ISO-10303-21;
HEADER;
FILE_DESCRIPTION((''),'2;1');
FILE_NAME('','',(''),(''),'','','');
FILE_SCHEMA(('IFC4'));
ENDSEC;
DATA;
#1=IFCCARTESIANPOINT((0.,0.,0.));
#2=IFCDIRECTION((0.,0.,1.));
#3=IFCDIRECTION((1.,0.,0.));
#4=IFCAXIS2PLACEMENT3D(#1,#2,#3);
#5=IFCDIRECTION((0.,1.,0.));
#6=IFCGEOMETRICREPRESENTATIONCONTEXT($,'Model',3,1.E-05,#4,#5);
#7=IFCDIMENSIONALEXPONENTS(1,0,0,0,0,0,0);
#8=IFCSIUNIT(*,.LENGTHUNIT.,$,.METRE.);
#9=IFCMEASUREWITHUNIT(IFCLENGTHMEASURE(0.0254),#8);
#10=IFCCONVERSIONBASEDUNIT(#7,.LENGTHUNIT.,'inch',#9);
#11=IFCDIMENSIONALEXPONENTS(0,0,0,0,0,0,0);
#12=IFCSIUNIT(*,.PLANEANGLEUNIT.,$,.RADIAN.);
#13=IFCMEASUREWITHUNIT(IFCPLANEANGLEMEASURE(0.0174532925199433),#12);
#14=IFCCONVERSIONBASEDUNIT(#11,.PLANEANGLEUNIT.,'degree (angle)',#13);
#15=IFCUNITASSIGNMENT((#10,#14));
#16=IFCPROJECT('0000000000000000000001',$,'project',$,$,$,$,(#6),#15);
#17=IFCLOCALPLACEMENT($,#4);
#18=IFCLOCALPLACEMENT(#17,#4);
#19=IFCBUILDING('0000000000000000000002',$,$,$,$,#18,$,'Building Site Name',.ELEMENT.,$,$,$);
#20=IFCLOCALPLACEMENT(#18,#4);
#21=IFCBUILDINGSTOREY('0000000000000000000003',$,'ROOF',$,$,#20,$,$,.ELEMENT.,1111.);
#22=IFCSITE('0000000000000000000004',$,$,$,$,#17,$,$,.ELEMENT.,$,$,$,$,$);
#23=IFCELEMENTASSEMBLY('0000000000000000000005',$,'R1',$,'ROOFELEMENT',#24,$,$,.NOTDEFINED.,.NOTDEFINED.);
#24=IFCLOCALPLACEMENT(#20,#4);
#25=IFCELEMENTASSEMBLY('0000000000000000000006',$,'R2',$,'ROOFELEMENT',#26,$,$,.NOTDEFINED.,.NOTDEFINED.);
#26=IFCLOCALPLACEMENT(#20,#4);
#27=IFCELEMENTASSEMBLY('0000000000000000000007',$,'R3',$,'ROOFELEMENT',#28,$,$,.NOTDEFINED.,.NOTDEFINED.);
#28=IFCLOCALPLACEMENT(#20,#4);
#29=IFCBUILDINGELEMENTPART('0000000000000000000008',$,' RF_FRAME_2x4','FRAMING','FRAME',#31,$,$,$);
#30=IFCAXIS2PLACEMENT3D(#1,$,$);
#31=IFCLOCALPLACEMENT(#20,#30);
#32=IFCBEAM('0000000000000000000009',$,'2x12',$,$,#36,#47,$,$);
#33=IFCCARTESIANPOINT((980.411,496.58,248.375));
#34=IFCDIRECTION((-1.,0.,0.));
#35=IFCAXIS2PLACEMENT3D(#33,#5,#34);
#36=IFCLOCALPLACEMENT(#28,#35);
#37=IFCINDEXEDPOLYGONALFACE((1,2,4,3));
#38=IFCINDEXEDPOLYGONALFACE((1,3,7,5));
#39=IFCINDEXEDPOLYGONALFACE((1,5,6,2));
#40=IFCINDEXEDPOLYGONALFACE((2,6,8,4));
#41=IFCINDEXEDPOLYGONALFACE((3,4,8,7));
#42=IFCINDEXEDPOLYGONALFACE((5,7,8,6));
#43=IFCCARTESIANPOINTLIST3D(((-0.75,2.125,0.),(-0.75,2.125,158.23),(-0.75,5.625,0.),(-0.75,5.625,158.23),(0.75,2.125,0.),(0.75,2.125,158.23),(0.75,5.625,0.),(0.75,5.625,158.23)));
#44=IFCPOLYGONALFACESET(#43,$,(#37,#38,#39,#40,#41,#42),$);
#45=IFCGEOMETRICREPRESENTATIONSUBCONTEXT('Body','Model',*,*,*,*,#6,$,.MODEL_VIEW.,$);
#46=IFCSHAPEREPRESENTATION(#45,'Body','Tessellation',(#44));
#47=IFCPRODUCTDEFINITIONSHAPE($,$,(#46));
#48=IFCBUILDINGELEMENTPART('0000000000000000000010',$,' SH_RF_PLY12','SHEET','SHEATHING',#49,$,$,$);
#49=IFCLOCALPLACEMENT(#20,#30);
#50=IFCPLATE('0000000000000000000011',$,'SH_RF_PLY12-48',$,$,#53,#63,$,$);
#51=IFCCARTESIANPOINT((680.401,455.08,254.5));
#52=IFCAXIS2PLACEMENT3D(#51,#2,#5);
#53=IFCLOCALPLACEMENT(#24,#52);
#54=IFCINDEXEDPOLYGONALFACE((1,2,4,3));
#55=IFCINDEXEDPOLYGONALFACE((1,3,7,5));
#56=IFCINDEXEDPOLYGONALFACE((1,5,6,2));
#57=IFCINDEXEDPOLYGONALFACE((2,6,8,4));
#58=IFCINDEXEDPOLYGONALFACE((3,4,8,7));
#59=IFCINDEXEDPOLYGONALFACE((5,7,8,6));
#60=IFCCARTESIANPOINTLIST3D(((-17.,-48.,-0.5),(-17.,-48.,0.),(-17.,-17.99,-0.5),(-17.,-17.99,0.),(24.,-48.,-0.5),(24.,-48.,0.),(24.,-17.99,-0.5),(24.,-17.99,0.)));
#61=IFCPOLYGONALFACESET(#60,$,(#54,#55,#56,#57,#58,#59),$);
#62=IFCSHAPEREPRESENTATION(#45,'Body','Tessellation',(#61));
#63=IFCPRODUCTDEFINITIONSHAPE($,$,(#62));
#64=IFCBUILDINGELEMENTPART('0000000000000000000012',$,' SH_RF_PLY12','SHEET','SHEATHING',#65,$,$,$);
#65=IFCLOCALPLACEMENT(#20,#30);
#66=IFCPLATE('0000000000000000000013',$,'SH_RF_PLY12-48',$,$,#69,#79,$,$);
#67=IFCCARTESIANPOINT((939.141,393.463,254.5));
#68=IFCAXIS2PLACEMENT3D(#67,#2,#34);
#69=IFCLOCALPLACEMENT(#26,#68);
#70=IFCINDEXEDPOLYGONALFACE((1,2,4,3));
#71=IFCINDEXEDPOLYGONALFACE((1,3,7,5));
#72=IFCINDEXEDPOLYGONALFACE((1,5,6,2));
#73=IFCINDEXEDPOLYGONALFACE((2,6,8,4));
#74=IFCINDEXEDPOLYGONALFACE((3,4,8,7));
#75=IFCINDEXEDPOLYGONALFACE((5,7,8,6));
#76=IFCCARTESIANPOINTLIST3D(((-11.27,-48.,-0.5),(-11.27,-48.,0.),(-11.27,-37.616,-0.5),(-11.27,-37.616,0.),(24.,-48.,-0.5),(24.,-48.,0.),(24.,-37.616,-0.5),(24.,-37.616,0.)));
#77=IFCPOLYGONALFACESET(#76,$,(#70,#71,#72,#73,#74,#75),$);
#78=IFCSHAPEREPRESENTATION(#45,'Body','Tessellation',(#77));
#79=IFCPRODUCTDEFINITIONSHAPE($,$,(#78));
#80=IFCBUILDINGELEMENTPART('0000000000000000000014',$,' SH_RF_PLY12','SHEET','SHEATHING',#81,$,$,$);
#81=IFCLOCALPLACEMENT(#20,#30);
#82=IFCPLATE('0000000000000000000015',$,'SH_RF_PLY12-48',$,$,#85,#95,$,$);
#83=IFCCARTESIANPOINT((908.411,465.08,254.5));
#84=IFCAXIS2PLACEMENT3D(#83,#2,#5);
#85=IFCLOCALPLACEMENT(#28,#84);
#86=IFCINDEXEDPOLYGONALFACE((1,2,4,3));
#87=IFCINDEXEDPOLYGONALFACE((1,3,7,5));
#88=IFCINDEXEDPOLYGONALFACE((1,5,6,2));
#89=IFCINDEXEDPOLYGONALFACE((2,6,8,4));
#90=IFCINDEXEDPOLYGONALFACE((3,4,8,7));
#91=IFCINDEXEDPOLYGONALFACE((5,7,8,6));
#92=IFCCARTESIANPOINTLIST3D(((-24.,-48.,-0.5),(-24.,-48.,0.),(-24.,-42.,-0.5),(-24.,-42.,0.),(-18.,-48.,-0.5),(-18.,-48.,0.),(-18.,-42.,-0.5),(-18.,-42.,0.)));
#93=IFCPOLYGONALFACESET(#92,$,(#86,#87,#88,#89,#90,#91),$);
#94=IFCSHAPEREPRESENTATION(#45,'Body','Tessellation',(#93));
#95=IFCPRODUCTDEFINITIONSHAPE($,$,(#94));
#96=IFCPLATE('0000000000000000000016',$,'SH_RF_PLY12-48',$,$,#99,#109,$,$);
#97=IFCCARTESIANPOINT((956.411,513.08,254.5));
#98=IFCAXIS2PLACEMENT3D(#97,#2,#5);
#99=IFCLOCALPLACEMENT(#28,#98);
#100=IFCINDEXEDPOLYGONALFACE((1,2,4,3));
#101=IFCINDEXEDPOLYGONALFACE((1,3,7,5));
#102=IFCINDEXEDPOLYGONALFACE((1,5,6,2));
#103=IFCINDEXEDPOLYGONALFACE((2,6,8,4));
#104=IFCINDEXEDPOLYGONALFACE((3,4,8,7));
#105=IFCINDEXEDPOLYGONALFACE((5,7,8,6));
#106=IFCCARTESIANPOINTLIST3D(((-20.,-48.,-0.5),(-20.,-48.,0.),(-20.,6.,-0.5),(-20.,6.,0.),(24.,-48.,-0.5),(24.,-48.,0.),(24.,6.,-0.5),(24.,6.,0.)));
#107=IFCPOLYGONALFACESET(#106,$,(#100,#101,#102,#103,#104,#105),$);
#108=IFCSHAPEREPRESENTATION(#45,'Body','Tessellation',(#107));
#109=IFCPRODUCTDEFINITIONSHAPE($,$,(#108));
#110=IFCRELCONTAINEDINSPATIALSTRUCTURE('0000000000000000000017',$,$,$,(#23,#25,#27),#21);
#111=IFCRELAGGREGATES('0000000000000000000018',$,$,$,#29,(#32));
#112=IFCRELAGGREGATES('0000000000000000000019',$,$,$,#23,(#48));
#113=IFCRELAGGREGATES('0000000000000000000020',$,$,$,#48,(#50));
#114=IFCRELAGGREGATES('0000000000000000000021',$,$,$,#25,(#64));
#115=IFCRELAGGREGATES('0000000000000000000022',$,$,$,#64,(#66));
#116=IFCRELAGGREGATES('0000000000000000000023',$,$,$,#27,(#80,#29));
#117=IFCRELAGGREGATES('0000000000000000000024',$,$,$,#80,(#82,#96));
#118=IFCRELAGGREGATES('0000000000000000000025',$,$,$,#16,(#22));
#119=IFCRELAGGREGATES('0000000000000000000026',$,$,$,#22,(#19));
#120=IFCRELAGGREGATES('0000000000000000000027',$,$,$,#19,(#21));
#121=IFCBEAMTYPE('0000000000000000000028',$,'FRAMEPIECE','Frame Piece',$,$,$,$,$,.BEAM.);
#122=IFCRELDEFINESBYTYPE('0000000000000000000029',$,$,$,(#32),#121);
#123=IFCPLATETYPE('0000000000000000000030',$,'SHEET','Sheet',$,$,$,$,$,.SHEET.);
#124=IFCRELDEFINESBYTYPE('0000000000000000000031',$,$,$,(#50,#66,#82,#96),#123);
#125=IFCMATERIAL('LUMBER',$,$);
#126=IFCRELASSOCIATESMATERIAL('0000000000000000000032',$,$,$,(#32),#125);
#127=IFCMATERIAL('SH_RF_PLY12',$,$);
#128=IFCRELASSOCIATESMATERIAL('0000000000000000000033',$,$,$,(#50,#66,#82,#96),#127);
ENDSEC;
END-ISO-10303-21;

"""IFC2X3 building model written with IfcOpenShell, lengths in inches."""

from ifc_helpers import new_model, entity, si_unit, converted_unit, direction, frame, frame_2d, origin_with_axes, place, context, subcontext, project, spatial, rectangle, extrude, material, type_object, element, aggregate, save


model = new_model("IFC2X3")

# Units and contexts
model_context = context("Model", 3, precision=1e-05, world=origin_with_axes(), true_north=direction((0.0, 1.0, 0.0)))
body_context = subcontext(model_context, "Body", "Model", "MODEL_VIEW")
ifc_project = project(units=[converted_unit("LENGTHUNIT", "inch", entity("IfcLengthMeasure", 0.0254), si_unit("LENGTHUNIT", "METRE"), dimensions=[1, 0, 0, 0, 0, 0, 0]), converted_unit("PLANEANGLEUNIT", "degree (angle)", entity("IfcPlaneAngleMeasure", 0.0174532925199433), si_unit("PLANEANGLEUNIT", "RADIAN"), dimensions=[0, 0, 0, 0, 0, 0, 0])], contexts=[model_context])

# Site, building, storey
site_placement = place(None, origin_with_axes())
site = spatial("IfcSite", under=ifc_project, at=site_placement, CompositionType="ELEMENT")
building_placement = place(site_placement, origin_with_axes())
building = spatial("IfcBuilding", under=site, at=building_placement, LongName="Building Site Name", CompositionType="ELEMENT")
storey_placement = place(building_placement, origin_with_axes())
storey = spatial("IfcBuildingStorey", under=building, at=storey_placement, Name="ROOF", CompositionType="ELEMENT", Elevation=1111.0)

# Element assemblies, building element part, beam
assembly_1_placement = place(storey_placement, origin_with_axes())
assembly_1 = element("IfcElementAssembly", 1, at=assembly_1_placement, inside=storey, Name="R1", ObjectType="ROOFELEMENT", AssemblyPlace="NOTDEFINED", PredefinedType="NOTDEFINED")
ifc_material_1 = material(Name="LUMBER")
beam_type = type_object("IfcBeamType", Name="FRAMEPIECE", Description="Frame Piece", PredefinedType="BEAM")
assembly_2_placement = place(storey_placement, origin_with_axes())
assembly_2 = element("IfcElementAssembly", 2, at=assembly_2_placement, inside=storey, Name="R2", ObjectType="ROOFELEMENT", AssemblyPlace="NOTDEFINED", PredefinedType="NOTDEFINED")
assembly_3_placement = place(storey_placement, origin_with_axes())
assembly_3 = element("IfcElementAssembly", 3, at=assembly_3_placement, inside=storey, Name="R3", ObjectType="ROOFELEMENT", AssemblyPlace="NOTDEFINED", PredefinedType="NOTDEFINED")
building_element_part_1 = element("IfcBuildingElementPart", 4, Name=" RF_FRAME_2x4", Description="FRAMING", ObjectType="FRAME")
beam_1_placement = place(assembly_3_placement, frame((980.411, 496.58, 248.375), z_axis=(0.0, 1.0, 0.0), x_axis=(-1.0, 0.0, 0.0)))
beam_1 = element("IfcBeam", 5, at=beam_1_placement, type_object=beam_type, material=ifc_material_1, Name="2x12", context=body_context, shape_type="SweptSolid", body=[
    extrude(rectangle(XDim=3.5, YDim=1.5, at=frame_2d((0.0, 3.875), x_axis=(0.0, -1.0))), origin_with_axes(), (0.0, 0.0, 1.0), 158.23),
])
aggregate(building_element_part_1, [beam_1])

# Building element part
building_element_part_2 = element("IfcBuildingElementPart", 6, Name=" SH_RF_PLY12", Description="SHEET", ObjectType="SHEATHING")
aggregate(assembly_1, [building_element_part_2])

# Plate
ifc_material_2 = material(Name="SH_RF_PLY12")
plate_type = type_object("IfcPlateType", Name="SHEET", Description="Sheet", PredefinedType="SHEET")
plate_1_placement = place(assembly_1_placement, frame((680.401, 455.08, 254.5), z_axis=(0.0, 0.0, 1.0), x_axis=(0.0, 1.0, 0.0)))
plate_1 = element("IfcPlate", 7, at=plate_1_placement, type_object=plate_type, material=ifc_material_2, Name="SH_RF_PLY12-48", context=body_context, shape_type="SweptSolid", body=[
    extrude(rectangle(XDim=0.5, YDim=41.0, at=frame_2d((-3.5, -0.25), x_axis=(0.0, -1.0))), frame((0.0, -48.0, 0.0), z_axis=(0.0, 1.0, 0.0), x_axis=(-1.0, 0.0, 0.0)), (0.0, 0.0, 1.0), 30.01),
])
aggregate(building_element_part_2, [plate_1])

# Building element part
building_element_part_3 = element("IfcBuildingElementPart", 8, Name=" SH_RF_PLY12", Description="SHEET", ObjectType="SHEATHING")
aggregate(assembly_2, [building_element_part_3])

# Plate
plate_2_placement = place(assembly_2_placement, frame((939.141, 393.463, 254.5), z_axis=(0.0, 0.0, 1.0), x_axis=(-1.0, 0.0, 0.0)))
plate_2 = element("IfcPlate", 9, at=plate_2_placement, type_object=plate_type, material=ifc_material_2, Name="SH_RF_PLY12-48", context=body_context, shape_type="SweptSolid", body=[
    extrude(rectangle(XDim=0.5, YDim=35.27, at=frame_2d((-6.365, -0.25), x_axis=(0.0, -1.0))), frame((0.0, -48.0, 0.0), z_axis=(0.0, 1.0, 0.0), x_axis=(-1.0, 0.0, 0.0)), (0.0, 0.0, 1.0), 10.384),
])
aggregate(building_element_part_3, [plate_2])

# Building element part
building_element_part_4 = element("IfcBuildingElementPart", 10, Name=" SH_RF_PLY12", Description="SHEET", ObjectType="SHEATHING")
aggregate(assembly_3, [building_element_part_4, building_element_part_1])

# Plates
plate_3_placement = place(assembly_3_placement, frame((908.411, 465.08, 254.5), z_axis=(0.0, 0.0, 1.0), x_axis=(0.0, 1.0, 0.0)))
plate_3 = element("IfcPlate", 11, at=plate_3_placement, type_object=plate_type, material=ifc_material_2, Name="SH_RF_PLY12-48", context=body_context, shape_type="SweptSolid", body=[
    extrude(rectangle(XDim=0.5, YDim=6.0, at=frame_2d((21.0, -0.25), x_axis=(0.0, -1.0))), frame((0.0, -48.0, 0.0), z_axis=(0.0, 1.0, 0.0), x_axis=(-1.0, 0.0, 0.0)), (0.0, 0.0, 1.0), 6.0),
])
plate_4_placement = place(assembly_3_placement, frame((956.411, 513.08, 254.5), z_axis=(0.0, 0.0, 1.0), x_axis=(0.0, 1.0, 0.0)))
plate_4 = element("IfcPlate", 12, at=plate_4_placement, type_object=plate_type, material=ifc_material_2, Name="SH_RF_PLY12-48", context=body_context, shape_type="SweptSolid", body=[
    extrude(rectangle(XDim=0.5, YDim=44.0, at=frame_2d((-2.0, -0.25), x_axis=(0.0, -1.0))), frame((0.0, -48.0, 0.0), z_axis=(0.0, 1.0, 0.0), x_axis=(-1.0, 0.0, 0.0)), (0.0, 0.0, 1.0), 54.0),
])
aggregate(building_element_part_4, [plate_3, plate_4])

save(model, "model.ifc")
